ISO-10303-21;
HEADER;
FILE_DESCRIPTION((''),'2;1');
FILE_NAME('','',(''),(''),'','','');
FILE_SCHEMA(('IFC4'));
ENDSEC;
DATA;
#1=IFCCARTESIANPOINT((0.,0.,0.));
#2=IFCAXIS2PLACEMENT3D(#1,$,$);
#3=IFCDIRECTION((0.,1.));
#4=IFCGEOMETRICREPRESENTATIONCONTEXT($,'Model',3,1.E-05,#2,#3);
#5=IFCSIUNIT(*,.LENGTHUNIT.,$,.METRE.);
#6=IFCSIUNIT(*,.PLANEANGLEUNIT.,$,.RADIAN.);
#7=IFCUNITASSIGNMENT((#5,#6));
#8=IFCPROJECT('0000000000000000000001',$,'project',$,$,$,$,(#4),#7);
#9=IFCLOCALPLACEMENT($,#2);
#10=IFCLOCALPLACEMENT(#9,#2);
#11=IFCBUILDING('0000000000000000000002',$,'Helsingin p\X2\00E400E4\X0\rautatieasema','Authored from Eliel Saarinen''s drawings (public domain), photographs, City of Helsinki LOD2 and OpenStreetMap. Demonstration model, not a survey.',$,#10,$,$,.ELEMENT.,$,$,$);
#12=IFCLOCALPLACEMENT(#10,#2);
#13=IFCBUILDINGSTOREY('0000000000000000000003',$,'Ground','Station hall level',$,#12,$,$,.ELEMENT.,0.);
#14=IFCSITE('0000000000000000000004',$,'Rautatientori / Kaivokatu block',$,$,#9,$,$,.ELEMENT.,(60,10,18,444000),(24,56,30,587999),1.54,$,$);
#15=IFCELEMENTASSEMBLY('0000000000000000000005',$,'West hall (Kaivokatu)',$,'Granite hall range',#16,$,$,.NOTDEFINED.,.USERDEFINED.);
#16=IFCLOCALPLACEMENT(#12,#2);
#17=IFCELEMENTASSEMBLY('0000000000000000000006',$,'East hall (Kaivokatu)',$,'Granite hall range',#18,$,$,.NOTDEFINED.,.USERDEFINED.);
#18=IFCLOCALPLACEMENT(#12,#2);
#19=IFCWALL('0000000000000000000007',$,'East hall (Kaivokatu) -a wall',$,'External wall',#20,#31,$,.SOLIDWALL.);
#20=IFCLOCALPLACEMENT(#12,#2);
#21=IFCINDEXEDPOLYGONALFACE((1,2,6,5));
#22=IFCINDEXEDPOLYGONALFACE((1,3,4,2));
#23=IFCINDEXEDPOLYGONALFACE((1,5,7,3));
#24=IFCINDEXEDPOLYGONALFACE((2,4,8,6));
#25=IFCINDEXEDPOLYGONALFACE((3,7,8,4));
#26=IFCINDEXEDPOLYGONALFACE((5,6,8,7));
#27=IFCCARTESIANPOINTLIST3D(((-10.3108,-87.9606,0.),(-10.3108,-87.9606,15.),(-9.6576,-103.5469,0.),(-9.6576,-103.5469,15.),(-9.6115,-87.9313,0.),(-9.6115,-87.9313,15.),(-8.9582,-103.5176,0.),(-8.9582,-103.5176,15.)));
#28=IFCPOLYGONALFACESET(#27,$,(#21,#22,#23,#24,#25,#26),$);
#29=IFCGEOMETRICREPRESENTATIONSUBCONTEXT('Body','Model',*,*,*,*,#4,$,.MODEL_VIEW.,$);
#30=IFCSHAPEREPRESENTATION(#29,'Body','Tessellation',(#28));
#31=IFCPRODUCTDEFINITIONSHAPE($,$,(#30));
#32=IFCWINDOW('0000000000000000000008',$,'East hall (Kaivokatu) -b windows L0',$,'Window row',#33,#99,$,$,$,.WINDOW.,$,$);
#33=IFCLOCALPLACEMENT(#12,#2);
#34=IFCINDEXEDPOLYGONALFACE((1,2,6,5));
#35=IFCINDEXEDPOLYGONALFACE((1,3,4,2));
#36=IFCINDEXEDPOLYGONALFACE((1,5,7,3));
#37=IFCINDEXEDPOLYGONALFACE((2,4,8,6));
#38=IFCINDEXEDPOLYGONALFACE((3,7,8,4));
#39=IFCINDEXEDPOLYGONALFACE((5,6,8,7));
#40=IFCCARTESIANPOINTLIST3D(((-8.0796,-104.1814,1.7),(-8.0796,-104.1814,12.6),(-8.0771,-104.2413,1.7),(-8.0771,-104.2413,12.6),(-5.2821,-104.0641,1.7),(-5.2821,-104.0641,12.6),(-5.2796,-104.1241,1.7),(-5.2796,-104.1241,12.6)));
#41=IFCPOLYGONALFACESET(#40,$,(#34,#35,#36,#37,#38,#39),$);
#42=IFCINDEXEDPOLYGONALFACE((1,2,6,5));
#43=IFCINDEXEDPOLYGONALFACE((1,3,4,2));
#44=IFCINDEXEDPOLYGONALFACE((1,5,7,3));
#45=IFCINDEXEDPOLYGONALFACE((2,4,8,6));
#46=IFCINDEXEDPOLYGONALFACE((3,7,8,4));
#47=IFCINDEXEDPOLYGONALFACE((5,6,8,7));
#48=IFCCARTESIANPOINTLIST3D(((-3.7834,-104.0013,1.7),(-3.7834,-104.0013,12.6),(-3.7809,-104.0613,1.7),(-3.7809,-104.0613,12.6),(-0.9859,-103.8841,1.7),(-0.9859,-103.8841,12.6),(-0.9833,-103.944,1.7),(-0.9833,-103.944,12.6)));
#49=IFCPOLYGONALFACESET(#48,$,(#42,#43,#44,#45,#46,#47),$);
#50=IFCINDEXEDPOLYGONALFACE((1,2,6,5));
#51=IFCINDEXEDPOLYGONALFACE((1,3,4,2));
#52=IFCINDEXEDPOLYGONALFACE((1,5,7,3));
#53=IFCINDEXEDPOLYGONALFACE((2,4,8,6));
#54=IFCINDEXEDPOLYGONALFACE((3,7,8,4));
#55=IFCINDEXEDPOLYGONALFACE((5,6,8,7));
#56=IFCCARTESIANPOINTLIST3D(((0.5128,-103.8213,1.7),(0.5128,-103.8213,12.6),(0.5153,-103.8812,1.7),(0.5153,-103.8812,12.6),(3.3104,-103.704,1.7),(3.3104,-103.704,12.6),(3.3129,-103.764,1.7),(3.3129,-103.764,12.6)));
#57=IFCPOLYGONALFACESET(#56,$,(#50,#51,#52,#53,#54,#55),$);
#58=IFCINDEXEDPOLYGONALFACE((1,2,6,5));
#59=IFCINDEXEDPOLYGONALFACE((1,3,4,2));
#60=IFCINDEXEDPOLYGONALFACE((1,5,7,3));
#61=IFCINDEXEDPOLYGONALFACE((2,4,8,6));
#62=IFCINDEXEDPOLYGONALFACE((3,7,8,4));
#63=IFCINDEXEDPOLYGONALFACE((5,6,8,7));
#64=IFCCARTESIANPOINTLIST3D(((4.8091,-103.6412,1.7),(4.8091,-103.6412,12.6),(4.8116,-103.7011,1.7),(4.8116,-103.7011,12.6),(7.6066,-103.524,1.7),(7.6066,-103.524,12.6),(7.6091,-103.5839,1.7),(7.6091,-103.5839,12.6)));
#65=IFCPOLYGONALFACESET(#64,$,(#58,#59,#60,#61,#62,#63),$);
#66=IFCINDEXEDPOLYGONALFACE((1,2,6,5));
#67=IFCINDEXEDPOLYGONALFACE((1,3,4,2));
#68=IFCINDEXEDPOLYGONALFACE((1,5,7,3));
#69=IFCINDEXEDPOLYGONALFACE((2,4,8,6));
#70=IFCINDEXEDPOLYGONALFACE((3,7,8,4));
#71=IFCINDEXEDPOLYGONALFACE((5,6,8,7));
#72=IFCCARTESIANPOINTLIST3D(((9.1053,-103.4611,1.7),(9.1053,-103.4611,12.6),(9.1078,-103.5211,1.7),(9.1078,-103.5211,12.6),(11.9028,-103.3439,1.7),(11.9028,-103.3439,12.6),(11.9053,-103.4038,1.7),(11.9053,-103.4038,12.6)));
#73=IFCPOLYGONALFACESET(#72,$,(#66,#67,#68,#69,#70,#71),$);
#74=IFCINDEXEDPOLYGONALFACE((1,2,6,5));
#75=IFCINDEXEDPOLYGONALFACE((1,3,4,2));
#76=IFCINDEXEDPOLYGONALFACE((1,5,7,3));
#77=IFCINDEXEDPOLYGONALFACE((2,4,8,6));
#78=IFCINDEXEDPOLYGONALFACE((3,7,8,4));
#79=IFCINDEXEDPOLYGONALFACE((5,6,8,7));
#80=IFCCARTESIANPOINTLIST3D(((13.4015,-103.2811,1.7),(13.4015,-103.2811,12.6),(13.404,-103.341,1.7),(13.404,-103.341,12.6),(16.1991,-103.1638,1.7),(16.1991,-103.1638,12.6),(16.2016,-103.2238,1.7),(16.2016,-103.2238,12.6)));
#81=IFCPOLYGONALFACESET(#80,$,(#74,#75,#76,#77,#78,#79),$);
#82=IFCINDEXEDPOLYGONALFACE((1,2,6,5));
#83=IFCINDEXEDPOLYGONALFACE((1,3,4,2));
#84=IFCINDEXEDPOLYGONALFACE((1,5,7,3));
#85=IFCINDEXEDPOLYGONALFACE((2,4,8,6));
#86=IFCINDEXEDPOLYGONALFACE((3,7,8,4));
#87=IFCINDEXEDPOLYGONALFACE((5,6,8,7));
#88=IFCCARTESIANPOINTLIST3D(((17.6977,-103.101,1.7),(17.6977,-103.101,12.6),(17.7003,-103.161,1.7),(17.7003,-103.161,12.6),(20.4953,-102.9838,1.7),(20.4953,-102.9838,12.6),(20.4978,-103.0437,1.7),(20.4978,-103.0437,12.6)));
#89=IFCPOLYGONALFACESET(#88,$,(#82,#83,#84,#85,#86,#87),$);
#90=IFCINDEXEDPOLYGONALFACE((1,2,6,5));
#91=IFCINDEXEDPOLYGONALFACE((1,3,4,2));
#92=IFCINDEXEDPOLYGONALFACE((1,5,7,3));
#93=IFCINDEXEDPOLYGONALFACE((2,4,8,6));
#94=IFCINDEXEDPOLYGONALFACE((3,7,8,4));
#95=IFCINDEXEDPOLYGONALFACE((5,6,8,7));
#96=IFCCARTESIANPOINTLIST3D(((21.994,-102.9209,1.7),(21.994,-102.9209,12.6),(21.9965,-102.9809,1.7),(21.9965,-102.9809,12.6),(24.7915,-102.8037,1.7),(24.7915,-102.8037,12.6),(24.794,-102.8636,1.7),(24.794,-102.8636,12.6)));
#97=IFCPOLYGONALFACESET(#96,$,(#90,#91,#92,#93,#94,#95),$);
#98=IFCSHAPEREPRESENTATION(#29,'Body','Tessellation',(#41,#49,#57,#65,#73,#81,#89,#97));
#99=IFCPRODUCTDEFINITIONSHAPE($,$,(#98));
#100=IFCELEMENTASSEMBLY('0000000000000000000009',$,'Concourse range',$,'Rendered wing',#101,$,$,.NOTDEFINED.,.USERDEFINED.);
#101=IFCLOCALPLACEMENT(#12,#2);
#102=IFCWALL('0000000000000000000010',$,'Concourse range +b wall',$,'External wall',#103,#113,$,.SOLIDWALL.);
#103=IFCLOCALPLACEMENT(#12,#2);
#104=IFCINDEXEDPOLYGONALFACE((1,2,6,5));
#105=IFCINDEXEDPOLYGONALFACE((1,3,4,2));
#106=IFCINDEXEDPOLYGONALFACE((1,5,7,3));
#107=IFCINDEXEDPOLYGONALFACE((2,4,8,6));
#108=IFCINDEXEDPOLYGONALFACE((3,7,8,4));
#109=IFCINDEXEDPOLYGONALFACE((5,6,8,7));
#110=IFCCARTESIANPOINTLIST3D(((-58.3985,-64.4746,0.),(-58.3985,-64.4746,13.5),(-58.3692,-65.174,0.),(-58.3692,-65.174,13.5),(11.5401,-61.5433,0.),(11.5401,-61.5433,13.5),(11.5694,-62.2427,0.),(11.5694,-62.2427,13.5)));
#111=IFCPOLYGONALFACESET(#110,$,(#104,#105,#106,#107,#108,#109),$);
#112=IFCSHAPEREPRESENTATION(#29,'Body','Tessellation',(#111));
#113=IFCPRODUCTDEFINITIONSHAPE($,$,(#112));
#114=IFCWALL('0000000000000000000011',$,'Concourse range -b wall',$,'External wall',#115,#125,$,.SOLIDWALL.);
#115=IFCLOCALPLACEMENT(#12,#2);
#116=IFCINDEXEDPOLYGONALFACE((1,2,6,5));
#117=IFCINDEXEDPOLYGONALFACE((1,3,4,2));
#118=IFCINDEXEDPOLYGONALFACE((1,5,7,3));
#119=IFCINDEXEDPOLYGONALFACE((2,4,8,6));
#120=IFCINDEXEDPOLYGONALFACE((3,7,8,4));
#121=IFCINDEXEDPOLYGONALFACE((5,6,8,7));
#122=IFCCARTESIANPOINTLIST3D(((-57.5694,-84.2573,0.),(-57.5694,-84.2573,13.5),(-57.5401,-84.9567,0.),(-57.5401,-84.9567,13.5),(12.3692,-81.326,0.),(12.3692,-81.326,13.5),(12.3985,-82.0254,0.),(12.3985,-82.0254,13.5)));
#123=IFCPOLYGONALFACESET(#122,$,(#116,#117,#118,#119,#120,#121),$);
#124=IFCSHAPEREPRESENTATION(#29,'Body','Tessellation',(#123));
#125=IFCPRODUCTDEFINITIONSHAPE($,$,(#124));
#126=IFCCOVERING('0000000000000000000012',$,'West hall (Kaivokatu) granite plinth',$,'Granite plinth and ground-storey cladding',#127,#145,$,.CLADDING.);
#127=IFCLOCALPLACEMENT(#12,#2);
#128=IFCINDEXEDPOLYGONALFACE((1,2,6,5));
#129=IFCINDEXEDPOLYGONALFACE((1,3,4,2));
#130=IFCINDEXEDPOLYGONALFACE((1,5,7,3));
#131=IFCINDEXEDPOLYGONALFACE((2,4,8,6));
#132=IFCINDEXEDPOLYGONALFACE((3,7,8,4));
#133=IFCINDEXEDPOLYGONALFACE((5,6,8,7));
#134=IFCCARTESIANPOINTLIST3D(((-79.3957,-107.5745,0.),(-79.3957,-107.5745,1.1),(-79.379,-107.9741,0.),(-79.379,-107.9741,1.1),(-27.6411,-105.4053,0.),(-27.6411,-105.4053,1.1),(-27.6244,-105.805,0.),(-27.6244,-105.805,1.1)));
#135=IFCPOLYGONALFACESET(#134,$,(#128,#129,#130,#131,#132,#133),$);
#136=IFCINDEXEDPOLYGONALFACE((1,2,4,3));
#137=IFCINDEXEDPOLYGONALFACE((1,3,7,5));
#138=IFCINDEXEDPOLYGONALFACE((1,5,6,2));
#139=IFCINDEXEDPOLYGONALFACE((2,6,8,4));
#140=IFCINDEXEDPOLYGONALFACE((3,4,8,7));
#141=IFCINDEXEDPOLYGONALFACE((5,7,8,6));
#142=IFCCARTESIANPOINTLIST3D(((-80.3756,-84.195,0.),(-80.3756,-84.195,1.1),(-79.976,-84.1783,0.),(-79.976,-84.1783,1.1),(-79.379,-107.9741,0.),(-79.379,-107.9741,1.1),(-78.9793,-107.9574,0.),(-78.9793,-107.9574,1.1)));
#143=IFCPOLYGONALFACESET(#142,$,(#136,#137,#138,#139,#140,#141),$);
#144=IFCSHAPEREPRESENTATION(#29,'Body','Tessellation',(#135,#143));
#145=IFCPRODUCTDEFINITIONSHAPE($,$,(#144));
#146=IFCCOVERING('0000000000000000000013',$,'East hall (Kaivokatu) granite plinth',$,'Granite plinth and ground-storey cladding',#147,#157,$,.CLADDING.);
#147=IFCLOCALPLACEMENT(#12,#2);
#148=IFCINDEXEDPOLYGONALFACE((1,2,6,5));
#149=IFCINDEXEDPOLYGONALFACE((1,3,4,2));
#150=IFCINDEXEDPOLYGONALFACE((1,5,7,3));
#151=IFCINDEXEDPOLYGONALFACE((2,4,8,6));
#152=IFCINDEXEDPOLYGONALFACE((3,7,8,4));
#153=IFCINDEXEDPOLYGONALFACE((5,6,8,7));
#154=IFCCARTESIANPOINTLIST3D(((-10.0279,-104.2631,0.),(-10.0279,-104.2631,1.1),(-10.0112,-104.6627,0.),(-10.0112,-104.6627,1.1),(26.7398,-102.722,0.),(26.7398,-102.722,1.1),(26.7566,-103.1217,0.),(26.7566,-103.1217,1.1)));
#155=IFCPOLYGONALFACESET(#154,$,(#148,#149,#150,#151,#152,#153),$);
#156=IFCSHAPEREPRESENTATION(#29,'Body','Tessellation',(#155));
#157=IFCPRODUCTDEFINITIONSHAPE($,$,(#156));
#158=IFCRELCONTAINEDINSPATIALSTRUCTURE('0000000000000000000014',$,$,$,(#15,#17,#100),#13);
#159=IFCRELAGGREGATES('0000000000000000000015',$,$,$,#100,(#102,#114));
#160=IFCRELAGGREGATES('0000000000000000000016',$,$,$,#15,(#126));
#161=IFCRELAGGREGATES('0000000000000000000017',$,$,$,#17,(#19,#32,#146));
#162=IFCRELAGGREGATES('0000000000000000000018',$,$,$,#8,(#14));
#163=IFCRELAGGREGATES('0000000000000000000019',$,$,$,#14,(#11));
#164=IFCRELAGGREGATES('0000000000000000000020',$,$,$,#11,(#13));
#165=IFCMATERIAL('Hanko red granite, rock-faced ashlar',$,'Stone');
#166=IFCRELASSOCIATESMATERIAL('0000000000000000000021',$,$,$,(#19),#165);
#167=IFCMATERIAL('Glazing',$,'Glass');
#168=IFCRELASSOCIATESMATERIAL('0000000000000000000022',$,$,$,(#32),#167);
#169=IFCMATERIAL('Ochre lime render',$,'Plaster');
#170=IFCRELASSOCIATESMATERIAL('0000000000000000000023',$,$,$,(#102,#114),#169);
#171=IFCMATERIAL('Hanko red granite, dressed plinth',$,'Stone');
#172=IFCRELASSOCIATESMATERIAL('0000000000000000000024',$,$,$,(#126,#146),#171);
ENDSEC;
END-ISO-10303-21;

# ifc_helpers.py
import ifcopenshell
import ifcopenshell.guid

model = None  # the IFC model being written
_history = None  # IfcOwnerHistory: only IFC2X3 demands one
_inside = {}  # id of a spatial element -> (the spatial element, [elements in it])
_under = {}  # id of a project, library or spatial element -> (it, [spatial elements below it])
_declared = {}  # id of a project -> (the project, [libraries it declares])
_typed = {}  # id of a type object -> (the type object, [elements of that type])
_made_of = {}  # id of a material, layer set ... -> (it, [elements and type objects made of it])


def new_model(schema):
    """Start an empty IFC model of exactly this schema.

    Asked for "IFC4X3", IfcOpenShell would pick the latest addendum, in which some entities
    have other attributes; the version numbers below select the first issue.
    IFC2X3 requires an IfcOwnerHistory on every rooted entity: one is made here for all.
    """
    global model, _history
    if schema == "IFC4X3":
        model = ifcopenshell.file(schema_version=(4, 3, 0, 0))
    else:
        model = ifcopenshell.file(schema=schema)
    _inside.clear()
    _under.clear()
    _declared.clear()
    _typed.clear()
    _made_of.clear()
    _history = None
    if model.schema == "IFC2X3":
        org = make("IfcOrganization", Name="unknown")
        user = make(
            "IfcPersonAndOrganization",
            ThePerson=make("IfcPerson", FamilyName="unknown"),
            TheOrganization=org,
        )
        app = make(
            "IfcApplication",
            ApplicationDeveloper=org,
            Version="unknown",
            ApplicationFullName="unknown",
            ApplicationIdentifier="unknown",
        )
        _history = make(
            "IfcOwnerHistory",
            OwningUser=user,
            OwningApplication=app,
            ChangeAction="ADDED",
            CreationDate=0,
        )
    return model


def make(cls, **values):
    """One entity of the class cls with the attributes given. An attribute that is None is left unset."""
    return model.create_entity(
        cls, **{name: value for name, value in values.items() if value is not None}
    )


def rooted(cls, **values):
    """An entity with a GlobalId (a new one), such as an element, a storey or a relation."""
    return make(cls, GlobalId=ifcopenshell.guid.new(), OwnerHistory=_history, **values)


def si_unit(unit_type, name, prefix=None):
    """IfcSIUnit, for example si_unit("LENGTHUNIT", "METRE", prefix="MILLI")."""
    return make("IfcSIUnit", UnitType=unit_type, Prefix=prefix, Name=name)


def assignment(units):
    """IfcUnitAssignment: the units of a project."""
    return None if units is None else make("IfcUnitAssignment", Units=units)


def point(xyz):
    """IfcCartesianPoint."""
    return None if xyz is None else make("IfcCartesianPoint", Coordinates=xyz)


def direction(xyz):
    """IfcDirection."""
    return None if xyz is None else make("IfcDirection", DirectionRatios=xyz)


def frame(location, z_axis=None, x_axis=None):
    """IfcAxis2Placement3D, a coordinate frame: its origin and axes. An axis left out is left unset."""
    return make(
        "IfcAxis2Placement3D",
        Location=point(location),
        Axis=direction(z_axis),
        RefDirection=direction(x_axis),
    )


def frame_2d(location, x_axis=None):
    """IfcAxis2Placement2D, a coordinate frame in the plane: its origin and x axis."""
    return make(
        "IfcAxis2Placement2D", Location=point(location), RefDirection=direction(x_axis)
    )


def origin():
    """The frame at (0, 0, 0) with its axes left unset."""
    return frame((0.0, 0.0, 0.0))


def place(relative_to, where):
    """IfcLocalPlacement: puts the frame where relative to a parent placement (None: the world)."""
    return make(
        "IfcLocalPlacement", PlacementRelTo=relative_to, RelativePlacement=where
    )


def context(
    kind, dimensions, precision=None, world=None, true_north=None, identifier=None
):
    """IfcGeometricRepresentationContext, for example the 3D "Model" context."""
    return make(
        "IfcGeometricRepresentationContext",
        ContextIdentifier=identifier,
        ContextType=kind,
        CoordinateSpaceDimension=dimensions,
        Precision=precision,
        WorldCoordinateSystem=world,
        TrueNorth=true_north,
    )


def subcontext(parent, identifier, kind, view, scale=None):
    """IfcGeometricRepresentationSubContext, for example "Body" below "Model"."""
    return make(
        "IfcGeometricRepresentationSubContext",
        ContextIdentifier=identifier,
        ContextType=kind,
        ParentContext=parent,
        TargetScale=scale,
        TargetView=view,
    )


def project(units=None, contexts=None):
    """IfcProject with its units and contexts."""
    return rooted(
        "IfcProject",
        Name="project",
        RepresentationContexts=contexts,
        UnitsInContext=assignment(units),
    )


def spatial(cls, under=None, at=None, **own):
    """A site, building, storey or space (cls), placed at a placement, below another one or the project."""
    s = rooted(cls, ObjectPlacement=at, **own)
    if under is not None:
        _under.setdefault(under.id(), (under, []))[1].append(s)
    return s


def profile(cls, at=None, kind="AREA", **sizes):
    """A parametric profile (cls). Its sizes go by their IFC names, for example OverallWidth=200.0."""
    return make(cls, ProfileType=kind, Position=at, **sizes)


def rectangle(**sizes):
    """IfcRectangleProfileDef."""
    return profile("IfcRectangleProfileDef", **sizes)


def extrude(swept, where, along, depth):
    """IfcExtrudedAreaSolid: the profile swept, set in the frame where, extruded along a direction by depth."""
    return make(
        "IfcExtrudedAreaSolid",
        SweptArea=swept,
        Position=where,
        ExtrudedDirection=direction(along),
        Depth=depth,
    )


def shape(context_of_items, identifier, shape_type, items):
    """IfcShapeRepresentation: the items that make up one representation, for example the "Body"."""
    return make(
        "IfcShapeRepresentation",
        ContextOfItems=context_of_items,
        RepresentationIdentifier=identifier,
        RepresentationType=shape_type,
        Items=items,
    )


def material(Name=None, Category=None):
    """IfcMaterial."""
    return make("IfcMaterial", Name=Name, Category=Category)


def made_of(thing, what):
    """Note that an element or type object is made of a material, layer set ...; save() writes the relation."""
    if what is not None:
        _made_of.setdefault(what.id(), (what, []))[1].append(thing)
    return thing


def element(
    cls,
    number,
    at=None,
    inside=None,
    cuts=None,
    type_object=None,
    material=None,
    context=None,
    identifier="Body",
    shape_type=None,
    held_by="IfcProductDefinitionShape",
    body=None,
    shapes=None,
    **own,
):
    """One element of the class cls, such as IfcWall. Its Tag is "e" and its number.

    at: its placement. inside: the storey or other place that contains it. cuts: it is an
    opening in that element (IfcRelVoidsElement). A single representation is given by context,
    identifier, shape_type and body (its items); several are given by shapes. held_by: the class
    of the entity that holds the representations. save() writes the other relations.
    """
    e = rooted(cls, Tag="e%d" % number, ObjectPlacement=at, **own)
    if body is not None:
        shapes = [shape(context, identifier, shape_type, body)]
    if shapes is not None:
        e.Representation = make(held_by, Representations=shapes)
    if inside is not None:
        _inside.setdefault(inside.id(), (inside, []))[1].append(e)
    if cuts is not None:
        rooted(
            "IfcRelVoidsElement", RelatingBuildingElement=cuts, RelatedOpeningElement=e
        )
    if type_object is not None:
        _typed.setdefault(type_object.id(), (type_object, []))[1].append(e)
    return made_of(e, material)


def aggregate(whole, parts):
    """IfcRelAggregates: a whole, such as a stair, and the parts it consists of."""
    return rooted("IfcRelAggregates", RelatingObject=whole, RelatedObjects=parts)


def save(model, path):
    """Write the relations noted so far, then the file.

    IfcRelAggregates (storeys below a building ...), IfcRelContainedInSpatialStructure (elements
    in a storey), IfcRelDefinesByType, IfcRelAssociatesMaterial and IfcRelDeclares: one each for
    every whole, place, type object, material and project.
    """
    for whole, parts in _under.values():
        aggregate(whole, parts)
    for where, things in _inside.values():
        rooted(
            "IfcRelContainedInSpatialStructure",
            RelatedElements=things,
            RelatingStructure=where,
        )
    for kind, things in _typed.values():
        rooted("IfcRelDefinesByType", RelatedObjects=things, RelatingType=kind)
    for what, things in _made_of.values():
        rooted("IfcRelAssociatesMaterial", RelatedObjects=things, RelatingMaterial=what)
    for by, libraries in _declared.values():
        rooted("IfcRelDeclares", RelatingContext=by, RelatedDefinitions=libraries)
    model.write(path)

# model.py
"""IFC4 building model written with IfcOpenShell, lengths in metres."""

from ifc_helpers import new_model, si_unit, direction, frame, frame_2d, origin, place, context, subcontext, project, spatial, rectangle, extrude, material, element, aggregate, save


model = new_model("IFC4")

# Units and contexts
model_context = context("Model", 3, precision=1e-05, world=origin(), true_north=direction((0.0, 1.0)))
body_context = subcontext(model_context, "Body", "Model", "MODEL_VIEW")
ifc_project = project(units=[si_unit("LENGTHUNIT", "METRE"), si_unit("PLANEANGLEUNIT", "RADIAN")], contexts=[model_context])

# Site, building, storey
site_placement = place(None, origin())
site = spatial("IfcSite", under=ifc_project, at=site_placement, Name="Rautatientori / Kaivokatu block", CompositionType="ELEMENT", RefLatitude=(60, 10, 18, 444000), RefLongitude=(24, 56, 30, 587999), RefElevation=1.54)
building_placement = place(site_placement, origin())
building = spatial("IfcBuilding", under=site, at=building_placement, Name="Helsingin päärautatieasema", Description="Authored from Eliel Saarinen's drawings (public domain), photographs, City of Helsinki LOD2 and OpenStreetMap. Demonstration model, not a survey.", CompositionType="ELEMENT")
storey_placement = place(building_placement, origin())
storey = spatial("IfcBuildingStorey", under=building, at=storey_placement, Name="Ground", Description="Station hall level", CompositionType="ELEMENT", Elevation=0.0)

# Element assemblies
assembly_1_placement = place(building_placement, origin())
assembly_1 = element("IfcElementAssembly", 1, at=assembly_1_placement, inside=storey, Name="West hall (Kaivokatu)", ObjectType="Granite hall range", AssemblyPlace="NOTDEFINED", PredefinedType="USERDEFINED")
ifc_material_1 = material(Name="Hanko red granite, rock-faced ashlar", Category="Stone")
assembly_2_placement = place(building_placement, origin())
assembly_2 = element("IfcElementAssembly", 2, at=assembly_2_placement, inside=storey, Name="East hall (Kaivokatu)", ObjectType="Granite hall range", AssemblyPlace="NOTDEFINED", PredefinedType="USERDEFINED")

# Shared definitions
ifc_material_2 = material(Name="Glazing", Category="Glass")

# Wall
wall_1_placement = place(building_placement, origin())
wall_1 = element("IfcWall", 3, at=wall_1_placement, material=ifc_material_1, Name="East hall (Kaivokatu) -a wall", ObjectType="External wall", PredefinedType="SOLIDWALL", context=body_context, shape_type="SweptSolid", body=[
    extrude(rectangle(XDim=15.6, YDim=0.7, at=frame_2d((0.0, 0.0), x_axis=(0.041876, -0.999123))), frame((-9.6345, -95.7391, 0.0)), (0.0, 0.0, 1.0), 15.0),
])

# Window
window_1_placement = place(building_placement, origin())
window_1 = element("IfcWindow", 4, at=window_1_placement, material=ifc_material_2, Name="East hall (Kaivokatu) -b windows L0", ObjectType="Window row", PredefinedType="WINDOW", context=body_context, shape_type="SweptSolid", body=[
    extrude(rectangle(XDim=2.8, YDim=0.06, at=frame_2d((0.0, 0.0), x_axis=(0.999123, 0.041876))), frame((-6.6796, -104.1527, 1.7)), (0.0, 0.0, 1.0), 10.9),
    extrude(rectangle(XDim=2.8, YDim=0.06, at=frame_2d((0.0, 0.0), x_axis=(0.999123, 0.041876))), frame((-2.3834, -103.9727, 1.7)), (0.0, 0.0, 1.0), 10.9),
    extrude(rectangle(XDim=2.8, YDim=0.06, at=frame_2d((0.0, 0.0), x_axis=(0.999123, 0.041876))), frame((1.9129, -103.7926, 1.7)), (0.0, 0.0, 1.0), 10.9),
    extrude(rectangle(XDim=2.8, YDim=0.06, at=frame_2d((0.0, 0.0), x_axis=(0.999123, 0.041876))), frame((6.2091, -103.6126, 1.7)), (0.0, 0.0, 1.0), 10.9),
    extrude(rectangle(XDim=2.8, YDim=0.06, at=frame_2d((0.0, 0.0), x_axis=(0.999123, 0.041876))), frame((10.5053, -103.4325, 1.7)), (0.0, 0.0, 1.0), 10.9),
    extrude(rectangle(XDim=2.8, YDim=0.06, at=frame_2d((0.0, 0.0), x_axis=(0.999123, 0.041876))), frame((14.8015, -103.2524, 1.7)), (0.0, 0.0, 1.0), 10.9),
    extrude(rectangle(XDim=2.8, YDim=0.06, at=frame_2d((0.0, 0.0), x_axis=(0.999123, 0.041876))), frame((19.0978, -103.0724, 1.7)), (0.0, 0.0, 1.0), 10.9),
    extrude(rectangle(XDim=2.8, YDim=0.06, at=frame_2d((0.0, 0.0), x_axis=(0.999123, 0.041876))), frame((23.394, -102.8923, 1.7)), (0.0, 0.0, 1.0), 10.9),
])

# Element assembly, walls
assembly_3_placement = place(building_placement, origin())
assembly_3 = element("IfcElementAssembly", 5, at=assembly_3_placement, inside=storey, Name="Concourse range", ObjectType="Rendered wing", AssemblyPlace="NOTDEFINED", PredefinedType="USERDEFINED")
ifc_material_3 = material(Name="Ochre lime render", Category="Plaster")
wall_2_placement = place(building_placement, origin())
wall_2 = element("IfcWall", 6, at=wall_2_placement, material=ifc_material_3, Name="Concourse range +b wall", ObjectType="External wall", PredefinedType="SOLIDWALL", context=body_context, shape_type="SweptSolid", body=[
    extrude(rectangle(XDim=70.0, YDim=0.7, at=frame_2d((0.0, 0.0), x_axis=(-0.999123, -0.041876))), frame((-23.4146, -63.3587, 0.0)), (0.0, 0.0, 1.0), 13.5),
])
wall_3_placement = place(building_placement, origin())
wall_3 = element("IfcWall", 7, at=wall_3_placement, material=ifc_material_3, Name="Concourse range -b wall", ObjectType="External wall", PredefinedType="SOLIDWALL", context=body_context, shape_type="SweptSolid", body=[
    extrude(rectangle(XDim=70.0, YDim=0.7, at=frame_2d((0.0, 0.0), x_axis=(0.999123, 0.041876))), frame((-22.5854, -83.1413, 0.0)), (0.0, 0.0, 1.0), 13.5),
])
aggregate(assembly_3, [wall_2, wall_3])

# Coverings
ifc_material_4 = material(Name="Hanko red granite, dressed plinth", Category="Stone")
covering_1_placement = place(building_placement, origin())
covering_1 = element("IfcCovering", 8, at=covering_1_placement, material=ifc_material_4, Name="West hall (Kaivokatu) granite plinth", ObjectType="Granite plinth and ground-storey cladding", PredefinedType="CLADDING", context=body_context, shape_type="SweptSolid", body=[
    extrude(rectangle(XDim=51.8, YDim=0.4, at=frame_2d((0.0, 0.0), x_axis=(0.999123, 0.041876))), frame((-53.5101, -106.6897, 0.0)), (0.0, 0.0, 1.0), 1.1),
    extrude(rectangle(XDim=23.8, YDim=0.4, at=frame_2d((0.0, 0.0), x_axis=(0.041876, -0.999123))), frame((-79.6775, -96.0762, 0.0)), (0.0, 0.0, 1.0), 1.1),
])
covering_2_placement = place(building_placement, origin())
covering_2 = element("IfcCovering", 9, at=covering_2_placement, material=ifc_material_4, Name="East hall (Kaivokatu) granite plinth", ObjectType="Granite plinth and ground-storey cladding", PredefinedType="CLADDING", context=body_context, shape_type="SweptSolid", body=[
    extrude(rectangle(XDim=36.8, YDim=0.4, at=frame_2d((0.0, 0.0), x_axis=(0.999123, 0.041876))), frame((8.3643, -103.6924, 0.0)), (0.0, 0.0, 1.0), 1.1),
])

aggregate(assembly_1, [covering_1])
aggregate(assembly_2, [wall_1, window_1, covering_2])

save(model, "model.ifc")
